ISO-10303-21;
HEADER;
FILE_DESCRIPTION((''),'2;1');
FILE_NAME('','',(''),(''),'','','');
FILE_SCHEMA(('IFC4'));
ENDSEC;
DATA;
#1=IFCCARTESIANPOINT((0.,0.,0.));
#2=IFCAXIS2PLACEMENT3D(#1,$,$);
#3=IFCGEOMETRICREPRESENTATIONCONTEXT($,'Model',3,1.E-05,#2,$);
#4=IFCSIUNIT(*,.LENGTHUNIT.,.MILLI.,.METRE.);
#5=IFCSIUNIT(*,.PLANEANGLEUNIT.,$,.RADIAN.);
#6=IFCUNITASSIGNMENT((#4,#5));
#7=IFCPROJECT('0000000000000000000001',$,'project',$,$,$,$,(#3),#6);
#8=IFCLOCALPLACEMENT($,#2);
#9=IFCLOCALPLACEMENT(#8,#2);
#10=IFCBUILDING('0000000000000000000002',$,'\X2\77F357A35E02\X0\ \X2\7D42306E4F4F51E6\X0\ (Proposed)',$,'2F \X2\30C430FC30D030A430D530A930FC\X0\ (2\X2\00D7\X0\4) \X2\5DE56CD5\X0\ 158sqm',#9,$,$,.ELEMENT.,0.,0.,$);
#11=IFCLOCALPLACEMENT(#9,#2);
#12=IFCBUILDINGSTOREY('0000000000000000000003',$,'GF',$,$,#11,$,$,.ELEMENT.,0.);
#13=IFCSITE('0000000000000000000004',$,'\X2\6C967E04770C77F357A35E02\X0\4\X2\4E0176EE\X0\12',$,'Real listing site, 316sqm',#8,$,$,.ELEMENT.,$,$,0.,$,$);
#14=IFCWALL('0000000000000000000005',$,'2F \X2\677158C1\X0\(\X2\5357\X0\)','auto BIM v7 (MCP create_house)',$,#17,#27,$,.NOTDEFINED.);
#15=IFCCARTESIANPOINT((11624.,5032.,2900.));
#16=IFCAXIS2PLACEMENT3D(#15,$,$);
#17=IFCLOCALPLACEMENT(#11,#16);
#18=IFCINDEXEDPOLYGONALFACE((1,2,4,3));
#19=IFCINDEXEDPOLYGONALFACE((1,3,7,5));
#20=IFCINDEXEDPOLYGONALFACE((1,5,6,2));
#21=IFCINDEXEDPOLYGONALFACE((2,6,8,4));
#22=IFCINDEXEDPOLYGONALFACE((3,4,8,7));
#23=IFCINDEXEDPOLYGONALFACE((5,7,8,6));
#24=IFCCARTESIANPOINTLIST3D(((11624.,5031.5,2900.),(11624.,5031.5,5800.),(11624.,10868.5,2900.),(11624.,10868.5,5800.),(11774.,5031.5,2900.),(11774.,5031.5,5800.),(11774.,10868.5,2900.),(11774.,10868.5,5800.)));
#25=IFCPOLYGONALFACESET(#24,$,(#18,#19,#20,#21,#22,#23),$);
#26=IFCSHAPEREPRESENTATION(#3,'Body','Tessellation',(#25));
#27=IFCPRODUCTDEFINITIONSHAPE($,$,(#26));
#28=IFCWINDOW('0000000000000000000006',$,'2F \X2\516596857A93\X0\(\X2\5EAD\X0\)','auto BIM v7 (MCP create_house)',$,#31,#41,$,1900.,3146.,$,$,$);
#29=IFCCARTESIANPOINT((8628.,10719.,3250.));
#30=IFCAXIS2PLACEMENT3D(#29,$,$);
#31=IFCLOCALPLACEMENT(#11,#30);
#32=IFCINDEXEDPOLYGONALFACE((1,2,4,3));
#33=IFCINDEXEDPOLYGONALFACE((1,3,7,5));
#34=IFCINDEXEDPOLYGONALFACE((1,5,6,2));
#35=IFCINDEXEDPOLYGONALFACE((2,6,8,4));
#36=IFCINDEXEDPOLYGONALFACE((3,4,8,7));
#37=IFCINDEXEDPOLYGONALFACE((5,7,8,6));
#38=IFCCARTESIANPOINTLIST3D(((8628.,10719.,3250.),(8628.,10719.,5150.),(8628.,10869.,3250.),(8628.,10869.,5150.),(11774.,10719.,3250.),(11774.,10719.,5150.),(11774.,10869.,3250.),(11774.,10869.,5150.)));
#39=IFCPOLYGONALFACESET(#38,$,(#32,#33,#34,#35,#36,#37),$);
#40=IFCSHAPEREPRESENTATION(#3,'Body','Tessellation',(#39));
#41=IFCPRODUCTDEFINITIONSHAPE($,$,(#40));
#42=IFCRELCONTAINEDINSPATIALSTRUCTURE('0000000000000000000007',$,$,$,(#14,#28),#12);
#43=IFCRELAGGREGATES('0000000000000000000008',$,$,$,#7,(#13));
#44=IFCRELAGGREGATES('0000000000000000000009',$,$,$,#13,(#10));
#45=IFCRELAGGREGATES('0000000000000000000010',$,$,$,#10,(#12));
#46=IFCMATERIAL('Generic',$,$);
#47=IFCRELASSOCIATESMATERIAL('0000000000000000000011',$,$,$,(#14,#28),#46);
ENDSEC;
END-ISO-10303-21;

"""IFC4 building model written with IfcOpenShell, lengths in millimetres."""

from ifc_helpers import new_model, si_unit, frame, frame_2d, origin, place, context, project, spatial, rectangle, extrude, material, element, fill, save


model = new_model("IFC4")

# Units and contexts
model_context = context("Model", 3, precision=1e-05, world=origin())
ifc_project = project(units=[si_unit("LENGTHUNIT", "METRE", prefix="MILLI"), si_unit("PLANEANGLEUNIT", "RADIAN")], contexts=[model_context])

# Site, building, storey
site_placement = place(None, origin())
site = spatial("IfcSite", under=ifc_project, at=site_placement, Name="沖縄県石垣市4丁目12", ObjectType="Real listing site, 316sqm", CompositionType="ELEMENT", RefElevation=0.0)
building_placement = place(site_placement, origin())
building = spatial("IfcBuilding", under=site, at=building_placement, Name="石垣市 終の住処 (Proposed)", ObjectType="2F ツーバイフォー (2×4) 工法 158sqm", CompositionType="ELEMENT", ElevationOfRefHeight=0.0, ElevationOfTerrain=0.0)
storey_placement = place(building_placement, origin())
storey = spatial("IfcBuildingStorey", under=building, at=storey_placement, Name="GF", CompositionType="ELEMENT", Elevation=0.0)

# Shared definitions
ifc_material = material(Name="Generic")

# Wall, opening, window
wall_1_placement = place(storey_placement, frame((11624.0, 5032.0, 2900.0)))
wall_1 = element("IfcWall", 1, at=wall_1_placement, inside=storey, material=ifc_material, Name="2F 東壁(南)", Description="auto BIM v7 (MCP create_house)", PredefinedType="NOTDEFINED", context=model_context, shape_type="SweptSolid", body=[
    extrude(rectangle(XDim=150.0, YDim=5837.0, at=frame_2d((75.0, 2918.0))), frame((11624.0, 5032.0, 2900.0)), (0.0, 0.0, 1.0), 2900.0),
])
opening_1_placement = place(storey_placement, frame((8628.0, 10719.0, 3250.0)))
opening_1 = element("IfcOpeningElement", 2, at=opening_1_placement, cuts=wall_1, PredefinedType="NOTDEFINED", context=model_context, shape_type="SweptSolid", body=[
    extrude(rectangle(XDim=3146.0, YDim=150.0, at=frame_2d((1573.0, 75.0))), frame((8628.0, 10719.0, 3250.0)), (0.0, 0.0, 1.0), 1900.0),
])
window_1_placement = place(storey_placement, frame((8628.0, 10719.0, 3250.0)))
window_1 = element("IfcWindow", 3, at=window_1_placement, inside=storey, material=ifc_material, Name="2F 入隅窓(庭)", Description="auto BIM v7 (MCP create_house)", OverallHeight=1900.0, OverallWidth=3146.0, context=model_context, shape_type="SweptSolid", body=[
    extrude(rectangle(XDim=3146.0, YDim=150.0, at=frame_2d((1573.0, 75.0))), frame((8628.0, 10719.0, 3250.0)), (0.0, 0.0, 1.0), 1900.0),
])
fill(opening_1, window_1)

save(model, "model.ifc")
